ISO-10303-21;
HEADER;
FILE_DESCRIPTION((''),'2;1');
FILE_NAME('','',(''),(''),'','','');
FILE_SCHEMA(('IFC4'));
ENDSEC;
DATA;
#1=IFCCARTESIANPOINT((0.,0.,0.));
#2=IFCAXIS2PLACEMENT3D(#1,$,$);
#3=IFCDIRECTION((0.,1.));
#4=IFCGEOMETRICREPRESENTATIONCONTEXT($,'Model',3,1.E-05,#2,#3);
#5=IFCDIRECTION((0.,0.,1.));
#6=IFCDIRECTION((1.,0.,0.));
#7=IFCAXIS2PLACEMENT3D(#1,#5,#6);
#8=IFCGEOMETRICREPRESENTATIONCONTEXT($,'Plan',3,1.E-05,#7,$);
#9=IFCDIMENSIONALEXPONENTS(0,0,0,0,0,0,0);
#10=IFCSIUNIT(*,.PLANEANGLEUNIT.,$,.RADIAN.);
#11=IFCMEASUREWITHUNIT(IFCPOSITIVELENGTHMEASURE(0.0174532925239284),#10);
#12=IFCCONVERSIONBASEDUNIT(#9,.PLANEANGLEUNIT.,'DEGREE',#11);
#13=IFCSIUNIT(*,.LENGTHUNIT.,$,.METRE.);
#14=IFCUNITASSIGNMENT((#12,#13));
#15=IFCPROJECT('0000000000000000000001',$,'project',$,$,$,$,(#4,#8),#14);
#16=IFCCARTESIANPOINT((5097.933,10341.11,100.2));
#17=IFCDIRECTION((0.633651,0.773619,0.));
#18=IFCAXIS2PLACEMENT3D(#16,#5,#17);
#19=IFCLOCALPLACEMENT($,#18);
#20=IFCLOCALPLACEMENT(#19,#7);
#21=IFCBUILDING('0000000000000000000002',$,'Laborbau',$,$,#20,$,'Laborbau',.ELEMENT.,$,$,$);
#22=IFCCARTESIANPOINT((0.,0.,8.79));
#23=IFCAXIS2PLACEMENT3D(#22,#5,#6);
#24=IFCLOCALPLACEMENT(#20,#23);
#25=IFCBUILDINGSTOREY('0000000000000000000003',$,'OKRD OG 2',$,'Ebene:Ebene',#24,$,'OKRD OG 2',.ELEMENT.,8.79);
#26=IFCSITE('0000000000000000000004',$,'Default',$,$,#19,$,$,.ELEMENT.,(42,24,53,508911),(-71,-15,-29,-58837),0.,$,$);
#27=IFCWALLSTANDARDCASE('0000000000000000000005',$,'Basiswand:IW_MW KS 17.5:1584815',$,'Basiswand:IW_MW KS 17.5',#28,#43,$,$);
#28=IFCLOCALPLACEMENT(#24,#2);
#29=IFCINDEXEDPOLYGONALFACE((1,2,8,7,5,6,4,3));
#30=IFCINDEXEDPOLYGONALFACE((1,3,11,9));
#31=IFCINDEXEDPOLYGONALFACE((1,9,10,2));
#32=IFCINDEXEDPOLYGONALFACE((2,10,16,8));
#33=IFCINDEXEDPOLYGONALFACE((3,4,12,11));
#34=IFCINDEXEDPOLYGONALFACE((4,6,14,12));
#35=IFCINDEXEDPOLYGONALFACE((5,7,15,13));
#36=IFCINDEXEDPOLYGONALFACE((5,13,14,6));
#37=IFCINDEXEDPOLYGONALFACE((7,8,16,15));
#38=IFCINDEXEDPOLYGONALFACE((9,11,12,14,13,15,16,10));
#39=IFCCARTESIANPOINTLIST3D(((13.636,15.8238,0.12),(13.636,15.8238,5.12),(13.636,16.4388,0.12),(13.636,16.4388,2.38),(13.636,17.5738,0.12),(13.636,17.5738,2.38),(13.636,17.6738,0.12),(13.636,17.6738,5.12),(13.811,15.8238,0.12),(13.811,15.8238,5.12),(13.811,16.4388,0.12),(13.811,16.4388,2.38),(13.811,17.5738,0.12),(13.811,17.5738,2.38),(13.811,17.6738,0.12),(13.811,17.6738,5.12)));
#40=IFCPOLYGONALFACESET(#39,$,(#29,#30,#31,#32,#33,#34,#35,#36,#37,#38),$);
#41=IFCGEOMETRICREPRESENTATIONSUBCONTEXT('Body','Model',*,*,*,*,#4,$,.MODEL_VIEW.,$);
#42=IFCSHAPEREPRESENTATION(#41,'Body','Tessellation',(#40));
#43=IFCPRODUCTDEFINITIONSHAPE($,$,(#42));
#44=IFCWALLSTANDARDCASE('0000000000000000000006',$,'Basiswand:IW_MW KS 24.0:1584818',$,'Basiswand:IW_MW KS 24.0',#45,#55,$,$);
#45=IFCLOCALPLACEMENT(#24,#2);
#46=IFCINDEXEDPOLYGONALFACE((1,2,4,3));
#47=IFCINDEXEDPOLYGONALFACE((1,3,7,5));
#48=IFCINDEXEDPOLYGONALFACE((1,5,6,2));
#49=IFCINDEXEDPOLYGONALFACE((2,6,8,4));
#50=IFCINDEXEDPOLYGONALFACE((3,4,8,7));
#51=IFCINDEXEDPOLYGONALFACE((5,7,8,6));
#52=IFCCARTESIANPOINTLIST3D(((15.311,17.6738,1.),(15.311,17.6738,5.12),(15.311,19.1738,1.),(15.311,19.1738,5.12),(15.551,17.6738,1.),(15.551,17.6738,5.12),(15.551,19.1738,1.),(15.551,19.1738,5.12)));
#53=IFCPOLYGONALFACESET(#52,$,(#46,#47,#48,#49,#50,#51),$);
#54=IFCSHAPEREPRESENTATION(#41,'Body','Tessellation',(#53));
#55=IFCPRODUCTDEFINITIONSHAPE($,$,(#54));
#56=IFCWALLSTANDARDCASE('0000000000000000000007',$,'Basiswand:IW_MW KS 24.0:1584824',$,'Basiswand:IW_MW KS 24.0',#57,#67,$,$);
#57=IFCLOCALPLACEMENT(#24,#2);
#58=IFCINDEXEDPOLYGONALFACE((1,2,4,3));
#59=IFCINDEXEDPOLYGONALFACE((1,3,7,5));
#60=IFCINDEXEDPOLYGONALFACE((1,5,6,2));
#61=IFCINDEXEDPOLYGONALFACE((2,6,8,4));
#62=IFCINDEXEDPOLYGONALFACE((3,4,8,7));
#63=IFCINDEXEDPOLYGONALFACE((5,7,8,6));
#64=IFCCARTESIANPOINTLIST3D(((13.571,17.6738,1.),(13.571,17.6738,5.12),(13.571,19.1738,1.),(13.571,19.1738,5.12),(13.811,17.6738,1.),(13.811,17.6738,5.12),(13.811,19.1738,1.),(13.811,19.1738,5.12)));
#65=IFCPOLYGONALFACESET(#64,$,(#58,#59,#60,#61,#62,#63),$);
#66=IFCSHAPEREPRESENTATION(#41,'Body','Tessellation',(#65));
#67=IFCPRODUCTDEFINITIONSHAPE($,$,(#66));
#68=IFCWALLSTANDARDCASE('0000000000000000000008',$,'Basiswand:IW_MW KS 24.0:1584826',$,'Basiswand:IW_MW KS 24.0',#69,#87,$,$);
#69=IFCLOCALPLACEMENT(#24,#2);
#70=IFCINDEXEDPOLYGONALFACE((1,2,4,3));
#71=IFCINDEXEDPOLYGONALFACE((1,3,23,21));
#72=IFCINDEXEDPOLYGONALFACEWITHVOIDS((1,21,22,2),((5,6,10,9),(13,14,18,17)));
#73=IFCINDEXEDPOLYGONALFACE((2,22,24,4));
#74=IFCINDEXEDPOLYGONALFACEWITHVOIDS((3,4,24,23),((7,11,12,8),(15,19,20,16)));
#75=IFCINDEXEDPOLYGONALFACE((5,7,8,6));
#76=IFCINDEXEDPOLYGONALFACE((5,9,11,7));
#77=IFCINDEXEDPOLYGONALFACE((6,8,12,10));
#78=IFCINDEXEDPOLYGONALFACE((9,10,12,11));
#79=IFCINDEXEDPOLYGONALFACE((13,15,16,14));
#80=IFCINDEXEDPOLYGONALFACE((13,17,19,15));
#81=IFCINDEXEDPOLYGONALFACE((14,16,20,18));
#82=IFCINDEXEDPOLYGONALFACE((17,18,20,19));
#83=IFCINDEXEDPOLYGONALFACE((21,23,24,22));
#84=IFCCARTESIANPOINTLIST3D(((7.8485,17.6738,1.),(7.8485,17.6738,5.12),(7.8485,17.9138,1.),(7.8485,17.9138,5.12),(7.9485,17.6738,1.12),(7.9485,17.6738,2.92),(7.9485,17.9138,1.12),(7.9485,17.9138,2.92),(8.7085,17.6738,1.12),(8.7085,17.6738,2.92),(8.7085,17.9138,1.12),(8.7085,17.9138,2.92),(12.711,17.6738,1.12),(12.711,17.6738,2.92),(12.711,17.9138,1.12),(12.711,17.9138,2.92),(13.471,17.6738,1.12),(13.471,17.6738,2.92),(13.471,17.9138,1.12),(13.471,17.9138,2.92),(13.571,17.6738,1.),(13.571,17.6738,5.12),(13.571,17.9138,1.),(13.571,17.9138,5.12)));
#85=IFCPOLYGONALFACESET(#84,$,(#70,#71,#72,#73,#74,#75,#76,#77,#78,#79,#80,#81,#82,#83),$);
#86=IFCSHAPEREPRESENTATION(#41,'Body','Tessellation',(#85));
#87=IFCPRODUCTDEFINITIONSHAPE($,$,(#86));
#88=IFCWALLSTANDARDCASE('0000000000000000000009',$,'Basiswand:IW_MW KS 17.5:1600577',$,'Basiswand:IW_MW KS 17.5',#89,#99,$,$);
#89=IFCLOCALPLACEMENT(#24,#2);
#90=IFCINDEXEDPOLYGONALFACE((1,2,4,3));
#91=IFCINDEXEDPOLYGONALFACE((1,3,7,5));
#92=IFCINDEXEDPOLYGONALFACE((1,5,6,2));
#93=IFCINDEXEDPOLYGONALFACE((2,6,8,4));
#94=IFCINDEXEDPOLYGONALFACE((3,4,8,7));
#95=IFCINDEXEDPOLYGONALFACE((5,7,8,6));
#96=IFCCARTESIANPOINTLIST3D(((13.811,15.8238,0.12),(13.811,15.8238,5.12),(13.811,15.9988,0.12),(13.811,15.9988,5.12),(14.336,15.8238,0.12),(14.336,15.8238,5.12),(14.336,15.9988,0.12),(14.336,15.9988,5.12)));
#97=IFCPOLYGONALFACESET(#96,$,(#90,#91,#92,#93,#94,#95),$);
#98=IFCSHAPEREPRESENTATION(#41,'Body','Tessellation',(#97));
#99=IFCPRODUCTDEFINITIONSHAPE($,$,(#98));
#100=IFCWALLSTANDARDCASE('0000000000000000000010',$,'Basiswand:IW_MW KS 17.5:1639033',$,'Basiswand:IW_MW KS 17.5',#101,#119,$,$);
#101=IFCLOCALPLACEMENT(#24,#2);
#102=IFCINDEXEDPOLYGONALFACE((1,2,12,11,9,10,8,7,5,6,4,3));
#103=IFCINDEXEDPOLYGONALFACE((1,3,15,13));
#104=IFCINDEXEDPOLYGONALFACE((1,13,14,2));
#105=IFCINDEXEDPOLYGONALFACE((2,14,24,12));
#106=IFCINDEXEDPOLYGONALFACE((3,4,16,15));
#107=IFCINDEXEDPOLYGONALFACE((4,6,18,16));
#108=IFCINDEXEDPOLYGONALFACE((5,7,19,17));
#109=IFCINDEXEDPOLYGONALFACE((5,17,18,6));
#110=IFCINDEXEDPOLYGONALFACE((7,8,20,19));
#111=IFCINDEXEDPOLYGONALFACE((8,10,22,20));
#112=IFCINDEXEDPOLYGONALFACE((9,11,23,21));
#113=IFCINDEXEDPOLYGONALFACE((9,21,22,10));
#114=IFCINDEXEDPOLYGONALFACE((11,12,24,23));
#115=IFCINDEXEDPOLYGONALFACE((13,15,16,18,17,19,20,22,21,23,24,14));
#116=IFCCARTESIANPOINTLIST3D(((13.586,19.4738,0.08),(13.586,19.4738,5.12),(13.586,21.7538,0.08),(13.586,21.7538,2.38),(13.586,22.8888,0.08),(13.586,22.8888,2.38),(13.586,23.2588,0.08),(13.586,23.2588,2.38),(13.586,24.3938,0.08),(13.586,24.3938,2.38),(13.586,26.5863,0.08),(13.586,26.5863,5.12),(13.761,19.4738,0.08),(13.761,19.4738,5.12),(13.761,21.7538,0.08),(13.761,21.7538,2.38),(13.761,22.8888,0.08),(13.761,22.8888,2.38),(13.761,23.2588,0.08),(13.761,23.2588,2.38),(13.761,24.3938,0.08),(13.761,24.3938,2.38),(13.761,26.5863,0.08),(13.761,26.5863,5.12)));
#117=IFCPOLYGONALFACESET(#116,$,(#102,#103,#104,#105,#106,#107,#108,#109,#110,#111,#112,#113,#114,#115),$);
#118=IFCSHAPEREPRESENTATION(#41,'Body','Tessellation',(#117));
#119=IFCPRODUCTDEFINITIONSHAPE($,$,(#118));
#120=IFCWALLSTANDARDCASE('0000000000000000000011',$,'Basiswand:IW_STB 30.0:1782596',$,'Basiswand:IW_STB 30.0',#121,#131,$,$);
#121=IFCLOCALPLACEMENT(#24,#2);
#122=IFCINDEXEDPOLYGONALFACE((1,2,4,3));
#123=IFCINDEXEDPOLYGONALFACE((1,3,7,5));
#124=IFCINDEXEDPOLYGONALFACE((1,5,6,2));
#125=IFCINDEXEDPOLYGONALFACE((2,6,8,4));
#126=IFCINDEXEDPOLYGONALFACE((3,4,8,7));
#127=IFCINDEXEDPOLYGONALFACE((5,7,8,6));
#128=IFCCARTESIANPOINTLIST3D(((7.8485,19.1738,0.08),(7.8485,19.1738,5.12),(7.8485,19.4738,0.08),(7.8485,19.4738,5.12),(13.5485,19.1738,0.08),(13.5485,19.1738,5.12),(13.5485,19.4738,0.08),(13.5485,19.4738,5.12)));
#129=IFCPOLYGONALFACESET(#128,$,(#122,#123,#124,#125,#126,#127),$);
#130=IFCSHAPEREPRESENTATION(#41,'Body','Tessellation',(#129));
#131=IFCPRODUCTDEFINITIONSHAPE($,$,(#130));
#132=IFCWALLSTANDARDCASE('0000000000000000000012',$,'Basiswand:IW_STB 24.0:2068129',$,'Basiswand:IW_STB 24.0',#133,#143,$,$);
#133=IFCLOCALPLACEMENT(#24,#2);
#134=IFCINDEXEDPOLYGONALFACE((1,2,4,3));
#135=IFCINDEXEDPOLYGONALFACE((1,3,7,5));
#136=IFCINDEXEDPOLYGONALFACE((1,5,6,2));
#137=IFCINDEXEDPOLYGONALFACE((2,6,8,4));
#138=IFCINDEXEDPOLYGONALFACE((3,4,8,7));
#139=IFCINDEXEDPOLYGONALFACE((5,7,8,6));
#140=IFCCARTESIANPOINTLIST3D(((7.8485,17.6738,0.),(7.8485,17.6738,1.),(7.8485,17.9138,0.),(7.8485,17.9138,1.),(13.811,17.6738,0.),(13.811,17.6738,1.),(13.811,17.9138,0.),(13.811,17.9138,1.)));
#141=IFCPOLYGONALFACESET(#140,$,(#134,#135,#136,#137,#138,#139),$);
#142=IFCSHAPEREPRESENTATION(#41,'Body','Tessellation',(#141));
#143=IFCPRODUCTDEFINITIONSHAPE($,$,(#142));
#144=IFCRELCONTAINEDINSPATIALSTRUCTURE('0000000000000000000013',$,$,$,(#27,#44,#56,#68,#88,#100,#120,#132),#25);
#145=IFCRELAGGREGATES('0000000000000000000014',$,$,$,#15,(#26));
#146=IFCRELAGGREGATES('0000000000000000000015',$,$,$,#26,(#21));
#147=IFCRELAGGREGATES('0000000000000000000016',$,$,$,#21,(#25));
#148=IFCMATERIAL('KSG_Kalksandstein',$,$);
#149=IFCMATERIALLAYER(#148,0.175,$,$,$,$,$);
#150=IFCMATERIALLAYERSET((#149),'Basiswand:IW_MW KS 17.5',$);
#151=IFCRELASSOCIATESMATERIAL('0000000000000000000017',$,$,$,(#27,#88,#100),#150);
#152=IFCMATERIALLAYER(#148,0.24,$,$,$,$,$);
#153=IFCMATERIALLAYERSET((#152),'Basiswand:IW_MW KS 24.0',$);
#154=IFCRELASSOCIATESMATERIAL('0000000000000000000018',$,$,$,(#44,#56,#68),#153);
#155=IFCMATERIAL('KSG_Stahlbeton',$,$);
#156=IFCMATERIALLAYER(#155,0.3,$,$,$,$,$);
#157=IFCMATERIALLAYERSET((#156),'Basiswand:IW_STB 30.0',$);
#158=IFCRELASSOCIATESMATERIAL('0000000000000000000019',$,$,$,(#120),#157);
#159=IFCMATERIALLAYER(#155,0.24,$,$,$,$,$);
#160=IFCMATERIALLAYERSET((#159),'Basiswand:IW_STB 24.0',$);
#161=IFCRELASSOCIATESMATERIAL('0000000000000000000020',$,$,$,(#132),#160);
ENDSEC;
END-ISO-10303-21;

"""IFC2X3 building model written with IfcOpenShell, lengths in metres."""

from ifc_helpers import new_model, entity, si_unit, converted_unit, direction, frame, frame_2d, origin, origin_with_axes, place, context, subcontext, project, spatial, polyline, rectangle, extrude, clip, bounded_halfspace, material, layer, layer_set, layer_usage, element, save


model = new_model("IFC2X3")

# Units and contexts
model_context = context("Model", 3, precision=1e-05, world=origin(), true_north=direction((0.0, 1.0)))
plan_context = context("Plan", 3, precision=1e-05, world=origin_with_axes())
body_context = subcontext(model_context, "Body", "Model", "MODEL_VIEW")
ifc_project = project(units=[converted_unit("PLANEANGLEUNIT", "DEGREE", entity("IfcPositiveLengthMeasure", 0.0174532925239284), si_unit("PLANEANGLEUNIT", "RADIAN"), dimensions=[0, 0, 0, 0, 0, 0, 0]), si_unit("LENGTHUNIT", "METRE")], contexts=[model_context, plan_context])

# Site, building, storey
site_placement = place(None, frame((5097.933, 10341.11, 100.2), z_axis=(0.0, 0.0, 1.0), x_axis=(0.633651, 0.773619, 0.0)))
site = spatial("IfcSite", under=ifc_project, at=site_placement, Name="Default", CompositionType="ELEMENT", RefLatitude=(42, 24, 53, 508911), RefLongitude=(-71, -15, -29, -58837), RefElevation=0.0)
building_placement = place(site_placement, origin_with_axes())
building = spatial("IfcBuilding", under=site, at=building_placement, Name="Laborbau", LongName="Laborbau", CompositionType="ELEMENT")
storey_placement = place(building_placement, frame((0.0, 0.0, 8.79), z_axis=(0.0, 0.0, 1.0), x_axis=(1.0, 0.0, 0.0)))
storey = spatial("IfcBuildingStorey", under=building, at=storey_placement, Name="OKRD OG 2", ObjectType="Ebene:Ebene", LongName="OKRD OG 2", CompositionType="ELEMENT", Elevation=8.79)

# Wall, opening
ifc_material_1 = material(Name="KSG_Kalksandstein")
ifc_layer_1 = layer(ifc_material_1, 0.175)
ifc_layer_set_1 = layer_set([ifc_layer_1], Name="Basiswand:IW_MW KS 17.5")
ifc_layer_usage_1 = layer_usage(ifc_layer_set_1, "AXIS2", "POSITIVE", -0.0875)
wall_1_placement = place(storey_placement, frame((13.7235, 15.8238, 0.12), z_axis=(0.0, 0.0, 1.0), x_axis=(0.0, 1.0, 0.0)))
wall_1 = element("IfcWallStandardCase", 1, at=wall_1_placement, inside=storey, material=ifc_layer_usage_1, Name="Basiswand:IW_MW KS 17.5:1584815", ObjectType="Basiswand:IW_MW KS 17.5", context=body_context, shape_type="SweptSolid", body=[
    extrude(rectangle(XDim=1.85, YDim=0.175, at=frame_2d((0.925, 0.0), x_axis=(-1.0, 0.0))), origin(), (0.0, 0.0, 1.0), 5.0),
])
opening_1_placement = place(wall_1_placement, frame((0.615, -0.0875, -0.12), z_axis=(0.0, 0.0, 1.0), x_axis=(1.0, 0.0, 0.0)))
element("IfcOpeningElement", 2, at=opening_1_placement, cuts=wall_1, ObjectType="Opening", context=body_context, shape_type="SweptSolid", body=[
    extrude(rectangle(XDim=2.38, YDim=1.135, at=frame_2d((1.19, 0.5675), x_axis=(1.0, 0.0))), frame((0.0, 0.0, 0.0), z_axis=(0.0, 1.0, 0.0), x_axis=(0.0, 0.0, 1.0)), (0.0, 0.0, 1.0), 0.175),
])

# Walls
ifc_layer_2 = layer(ifc_material_1, 0.24)
ifc_layer_set_2 = layer_set([ifc_layer_2], Name="Basiswand:IW_MW KS 24.0")
ifc_layer_usage_2 = layer_usage(ifc_layer_set_2, "AXIS2", "POSITIVE", -0.12)
wall_2_placement = place(storey_placement, frame((15.431, 19.1738, 1.0), z_axis=(0.0, 0.0, 1.0), x_axis=(0.0, -1.0, 0.0)))
element("IfcWallStandardCase", 3, at=wall_2_placement, inside=storey, material=ifc_layer_usage_2, Name="Basiswand:IW_MW KS 24.0:1584818", ObjectType="Basiswand:IW_MW KS 24.0", context=body_context, shape_type="SweptSolid", body=[
    extrude(rectangle(XDim=1.5, YDim=0.24, at=frame_2d((0.75, 0.0), x_axis=(-1.0, 0.0))), origin(), (0.0, 0.0, 1.0), 4.12),
])
ifc_layer_usage_3 = layer_usage(ifc_layer_set_2, "AXIS2", "POSITIVE", -0.12)
wall_3_placement = place(storey_placement, frame((13.691, 17.6738, 1.0), z_axis=(0.0, 0.0, 1.0), x_axis=(0.0, 1.0, 0.0)))
element("IfcWallStandardCase", 4, at=wall_3_placement, inside=storey, material=ifc_layer_usage_3, Name="Basiswand:IW_MW KS 24.0:1584824", ObjectType="Basiswand:IW_MW KS 24.0", context=body_context, shape_type="SweptSolid", body=[
    extrude(rectangle(XDim=1.5, YDim=0.24, at=frame_2d((0.75, 0.0), x_axis=(-1.0, 0.0))), origin(), (0.0, 0.0, 1.0), 4.12),
])

# Wall, openings
ifc_layer_usage_4 = layer_usage(ifc_layer_set_2, "AXIS2", "NEGATIVE", 0.12)
wall_4_placement = place(storey_placement, frame((13.571, 17.7938, 1.0), z_axis=(0.0, 0.0, 1.0), x_axis=(-1.0, 0.0, 0.0)))
wall_4 = element("IfcWallStandardCase", 5, at=wall_4_placement, inside=storey, material=ifc_layer_usage_4, Name="Basiswand:IW_MW KS 24.0:1584826", ObjectType="Basiswand:IW_MW KS 24.0", context=body_context, shape_type="SweptSolid", body=[
    extrude(rectangle(XDim=5.7225, YDim=0.24, at=frame_2d((2.8612, 0.0), x_axis=(-1.0, 0.0))), origin(), (0.0, 0.0, 1.0), 4.12),
])
opening_2_placement = place(wall_4_placement, frame((13.571, 17.7938, -1.0), z_axis=(0.0, 0.0, 1.0), x_axis=(-1.0, 0.0, 0.0)))
element("IfcOpeningElement", 6, at=opening_2_placement, cuts=wall_4, ObjectType="Opening", context=body_context, shape_type="SweptSolid", body=[
    extrude(rectangle(XDim=1.8, YDim=0.76, at=frame_2d((0.0, 0.0), x_axis=(1.0, 0.0))), frame((8.3285, 19.4378, 2.02), z_axis=(0.0, -1.0, 0.0), x_axis=(0.0, 0.0, 1.0)), (0.0, 0.0, 1.0), 3.048),
])
opening_3_placement = place(wall_4_placement, frame((4.8625, -0.12, 0.12), z_axis=(0.0, 0.0, 1.0), x_axis=(1.0, 0.0, 0.0)))
element("IfcOpeningElement", 7, at=opening_3_placement, cuts=wall_4, ObjectType="Opening", context=body_context, shape_type="SweptSolid", body=[
    extrude(rectangle(XDim=1.8, YDim=0.76, at=frame_2d((0.9, 0.38), x_axis=(1.0, 0.0))), frame((0.0, 0.0, 0.0), z_axis=(0.0, 1.0, 0.0), x_axis=(0.0, 0.0, 1.0)), (0.0, 0.0, 1.0), 0.24),
])
opening_4_placement = place(wall_4_placement, frame((13.571, 17.7938, -1.0), z_axis=(0.0, 0.0, 1.0), x_axis=(-1.0, 0.0, 0.0)))
element("IfcOpeningElement", 8, at=opening_4_placement, cuts=wall_4, ObjectType="Opening", context=body_context, shape_type="SweptSolid", body=[
    extrude(rectangle(XDim=1.8, YDim=0.76, at=frame_2d((0.0, 0.0), x_axis=(0.0, 1.0))), frame((13.091, 19.4378, 2.02), z_axis=(0.0, -1.0, 0.0), x_axis=(1.0, 0.0, 0.0)), (0.0, 0.0, 1.0), 3.048),
])
opening_5_placement = place(wall_4_placement, frame((0.1, -0.12, 0.12), z_axis=(0.0, 0.0, 1.0), x_axis=(1.0, 0.0, 0.0)))
element("IfcOpeningElement", 9, at=opening_5_placement, cuts=wall_4, ObjectType="Opening", context=body_context, shape_type="SweptSolid", body=[
    extrude(rectangle(XDim=1.8, YDim=0.76, at=frame_2d((0.9, 0.38), x_axis=(1.0, 0.0))), frame((0.0, 0.0, 0.0), z_axis=(0.0, 1.0, 0.0), x_axis=(0.0, 0.0, 1.0)), (0.0, 0.0, 1.0), 0.24),
])

# Wall
ifc_layer_usage_5 = layer_usage(ifc_layer_set_1, "AXIS2", "NEGATIVE", 0.0875)
wall_5_placement = place(storey_placement, frame((13.811, 15.9113, 0.12), z_axis=(0.0, 0.0, 1.0), x_axis=(1.0, 0.0, 0.0)))
element("IfcWallStandardCase", 10, at=wall_5_placement, inside=storey, material=ifc_layer_usage_5, Name="Basiswand:IW_MW KS 17.5:1600577", ObjectType="Basiswand:IW_MW KS 17.5", context=body_context, shape_type="Clipping", body=[
    clip(extrude(rectangle(XDim=0.525, YDim=0.175, at=frame_2d((0.2625, 0.0), x_axis=(-1.0, 0.0))), origin(), (0.0, 0.0, 1.0), 5.0), bounded_halfspace(frame((0.0, -0.0875, 5.0), z_axis=(0.0, 0.0, -1.0), x_axis=(0.0, -1.0, 0.0)), True, frame((0.0, -0.0875, 5.0)), polyline([(0.0, 0.0), (0.525, 0.0), (0.525, 0.175), (0.0, 0.175), (0.0, 0.0)]))),
])

# Wall, openings
ifc_layer_usage_6 = layer_usage(ifc_layer_set_1, "AXIS2", "NEGATIVE", 0.0875)
wall_6_placement = place(storey_placement, frame((13.6735, 19.4738, 0.08), z_axis=(0.0, 0.0, 1.0), x_axis=(0.0, 1.0, 0.0)))
wall_6 = element("IfcWallStandardCase", 11, at=wall_6_placement, inside=storey, material=ifc_layer_usage_6, Name="Basiswand:IW_MW KS 17.5:1639033", ObjectType="Basiswand:IW_MW KS 17.5", context=body_context, shape_type="SweptSolid", body=[
    extrude(rectangle(XDim=7.1125, YDim=0.175, at=frame_2d((3.5562, 0.0), x_axis=(-1.0, 0.0))), origin(), (0.0, 0.0, 1.0), 5.04),
])
opening_6_placement = place(wall_6_placement, frame((-19.4738, 13.6735, -0.08), z_axis=(0.0, 0.0, 1.0), x_axis=(0.0, -1.0, 0.0)))
element("IfcOpeningElement", 12, at=opening_6_placement, cuts=wall_6, ObjectType="Opening", context=body_context, shape_type="SweptSolid", body=[
    extrude(rectangle(XDim=2.38, YDim=1.135, at=frame_2d((0.0, 0.0), x_axis=(1.0, 0.0))), frame((15.285, 22.3213, 1.19), z_axis=(-1.0, 0.0, 0.0), x_axis=(0.0, 0.0, 1.0)), (0.0, 0.0, 1.0), 3.048),
])
opening_7_placement = place(wall_6_placement, frame((2.28, -0.0875, -0.08), z_axis=(0.0, 0.0, 1.0), x_axis=(1.0, 0.0, 0.0)))
element("IfcOpeningElement", 13, at=opening_7_placement, cuts=wall_6, ObjectType="Opening", context=body_context, shape_type="SweptSolid", body=[
    extrude(rectangle(XDim=2.38, YDim=1.135, at=frame_2d((1.19, 0.5675), x_axis=(1.0, 0.0))), frame((0.0, 0.0, 0.0), z_axis=(0.0, 1.0, 0.0), x_axis=(0.0, 0.0, 1.0)), (0.0, 0.0, 1.0), 0.175),
])
opening_8_placement = place(wall_6_placement, frame((-19.4738, 13.6735, -0.08), z_axis=(0.0, 0.0, 1.0), x_axis=(0.0, -1.0, 0.0)))
element("IfcOpeningElement", 14, at=opening_8_placement, cuts=wall_6, ObjectType="Opening", context=body_context, shape_type="SweptSolid", body=[
    extrude(rectangle(XDim=2.38, YDim=1.135, at=frame_2d((0.0, 0.0), x_axis=(0.0, 1.0))), frame((15.285, 23.8263, 1.19), z_axis=(-1.0, 0.0, 0.0), x_axis=(0.0, -1.0, 0.0)), (0.0, 0.0, 1.0), 3.048),
])
opening_9_placement = place(wall_6_placement, frame((3.785, -0.0875, -0.08), z_axis=(0.0, 0.0, 1.0), x_axis=(1.0, 0.0, 0.0)))
element("IfcOpeningElement", 15, at=opening_9_placement, cuts=wall_6, ObjectType="Opening", context=body_context, shape_type="SweptSolid", body=[
    extrude(rectangle(XDim=2.38, YDim=1.135, at=frame_2d((1.19, 0.5675), x_axis=(1.0, 0.0))), frame((0.0, 0.0, 0.0), z_axis=(0.0, 1.0, 0.0), x_axis=(0.0, 0.0, 1.0)), (0.0, 0.0, 1.0), 0.175),
])

# Walls
ifc_material_2 = material(Name="KSG_Stahlbeton")
ifc_layer_3 = layer(ifc_material_2, 0.3)
ifc_layer_set_3 = layer_set([ifc_layer_3], Name="Basiswand:IW_STB 30.0")
ifc_layer_usage_7 = layer_usage(ifc_layer_set_3, "AXIS2", "POSITIVE", -0.15)
wall_7_placement = place(storey_placement, frame((13.5485, 19.3238, 0.08), z_axis=(0.0, 0.0, 1.0), x_axis=(-1.0, 0.0, 0.0)))
element("IfcWallStandardCase", 16, at=wall_7_placement, inside=storey, material=ifc_layer_usage_7, Name="Basiswand:IW_STB 30.0:1782596", ObjectType="Basiswand:IW_STB 30.0", context=body_context, shape_type="SweptSolid", body=[
    extrude(rectangle(XDim=5.7, YDim=0.3, at=frame_2d((2.85, 0.0), x_axis=(-1.0, 0.0))), origin(), (0.0, 0.0, 1.0), 5.04),
])
ifc_layer_4 = layer(ifc_material_2, 0.24)
ifc_layer_set_4 = layer_set([ifc_layer_4], Name="Basiswand:IW_STB 24.0")
ifc_layer_usage_8 = layer_usage(ifc_layer_set_4, "AXIS2", "NEGATIVE", 0.12)
wall_8_placement = place(storey_placement, frame((7.8485, 17.7938, 0.0), z_axis=(0.0, 0.0, 1.0), x_axis=(1.0, 0.0, 0.0)))
element("IfcWallStandardCase", 17, at=wall_8_placement, inside=storey, material=ifc_layer_usage_8, Name="Basiswand:IW_STB 24.0:2068129", ObjectType="Basiswand:IW_STB 24.0", context=body_context, shape_type="SweptSolid", body=[
    extrude(rectangle(XDim=5.9625, YDim=0.24, at=frame_2d((2.9812, 0.0), x_axis=(-1.0, 0.0))), origin(), (0.0, 0.0, 1.0), 1.0),
])

save(model, "model.ifc")
